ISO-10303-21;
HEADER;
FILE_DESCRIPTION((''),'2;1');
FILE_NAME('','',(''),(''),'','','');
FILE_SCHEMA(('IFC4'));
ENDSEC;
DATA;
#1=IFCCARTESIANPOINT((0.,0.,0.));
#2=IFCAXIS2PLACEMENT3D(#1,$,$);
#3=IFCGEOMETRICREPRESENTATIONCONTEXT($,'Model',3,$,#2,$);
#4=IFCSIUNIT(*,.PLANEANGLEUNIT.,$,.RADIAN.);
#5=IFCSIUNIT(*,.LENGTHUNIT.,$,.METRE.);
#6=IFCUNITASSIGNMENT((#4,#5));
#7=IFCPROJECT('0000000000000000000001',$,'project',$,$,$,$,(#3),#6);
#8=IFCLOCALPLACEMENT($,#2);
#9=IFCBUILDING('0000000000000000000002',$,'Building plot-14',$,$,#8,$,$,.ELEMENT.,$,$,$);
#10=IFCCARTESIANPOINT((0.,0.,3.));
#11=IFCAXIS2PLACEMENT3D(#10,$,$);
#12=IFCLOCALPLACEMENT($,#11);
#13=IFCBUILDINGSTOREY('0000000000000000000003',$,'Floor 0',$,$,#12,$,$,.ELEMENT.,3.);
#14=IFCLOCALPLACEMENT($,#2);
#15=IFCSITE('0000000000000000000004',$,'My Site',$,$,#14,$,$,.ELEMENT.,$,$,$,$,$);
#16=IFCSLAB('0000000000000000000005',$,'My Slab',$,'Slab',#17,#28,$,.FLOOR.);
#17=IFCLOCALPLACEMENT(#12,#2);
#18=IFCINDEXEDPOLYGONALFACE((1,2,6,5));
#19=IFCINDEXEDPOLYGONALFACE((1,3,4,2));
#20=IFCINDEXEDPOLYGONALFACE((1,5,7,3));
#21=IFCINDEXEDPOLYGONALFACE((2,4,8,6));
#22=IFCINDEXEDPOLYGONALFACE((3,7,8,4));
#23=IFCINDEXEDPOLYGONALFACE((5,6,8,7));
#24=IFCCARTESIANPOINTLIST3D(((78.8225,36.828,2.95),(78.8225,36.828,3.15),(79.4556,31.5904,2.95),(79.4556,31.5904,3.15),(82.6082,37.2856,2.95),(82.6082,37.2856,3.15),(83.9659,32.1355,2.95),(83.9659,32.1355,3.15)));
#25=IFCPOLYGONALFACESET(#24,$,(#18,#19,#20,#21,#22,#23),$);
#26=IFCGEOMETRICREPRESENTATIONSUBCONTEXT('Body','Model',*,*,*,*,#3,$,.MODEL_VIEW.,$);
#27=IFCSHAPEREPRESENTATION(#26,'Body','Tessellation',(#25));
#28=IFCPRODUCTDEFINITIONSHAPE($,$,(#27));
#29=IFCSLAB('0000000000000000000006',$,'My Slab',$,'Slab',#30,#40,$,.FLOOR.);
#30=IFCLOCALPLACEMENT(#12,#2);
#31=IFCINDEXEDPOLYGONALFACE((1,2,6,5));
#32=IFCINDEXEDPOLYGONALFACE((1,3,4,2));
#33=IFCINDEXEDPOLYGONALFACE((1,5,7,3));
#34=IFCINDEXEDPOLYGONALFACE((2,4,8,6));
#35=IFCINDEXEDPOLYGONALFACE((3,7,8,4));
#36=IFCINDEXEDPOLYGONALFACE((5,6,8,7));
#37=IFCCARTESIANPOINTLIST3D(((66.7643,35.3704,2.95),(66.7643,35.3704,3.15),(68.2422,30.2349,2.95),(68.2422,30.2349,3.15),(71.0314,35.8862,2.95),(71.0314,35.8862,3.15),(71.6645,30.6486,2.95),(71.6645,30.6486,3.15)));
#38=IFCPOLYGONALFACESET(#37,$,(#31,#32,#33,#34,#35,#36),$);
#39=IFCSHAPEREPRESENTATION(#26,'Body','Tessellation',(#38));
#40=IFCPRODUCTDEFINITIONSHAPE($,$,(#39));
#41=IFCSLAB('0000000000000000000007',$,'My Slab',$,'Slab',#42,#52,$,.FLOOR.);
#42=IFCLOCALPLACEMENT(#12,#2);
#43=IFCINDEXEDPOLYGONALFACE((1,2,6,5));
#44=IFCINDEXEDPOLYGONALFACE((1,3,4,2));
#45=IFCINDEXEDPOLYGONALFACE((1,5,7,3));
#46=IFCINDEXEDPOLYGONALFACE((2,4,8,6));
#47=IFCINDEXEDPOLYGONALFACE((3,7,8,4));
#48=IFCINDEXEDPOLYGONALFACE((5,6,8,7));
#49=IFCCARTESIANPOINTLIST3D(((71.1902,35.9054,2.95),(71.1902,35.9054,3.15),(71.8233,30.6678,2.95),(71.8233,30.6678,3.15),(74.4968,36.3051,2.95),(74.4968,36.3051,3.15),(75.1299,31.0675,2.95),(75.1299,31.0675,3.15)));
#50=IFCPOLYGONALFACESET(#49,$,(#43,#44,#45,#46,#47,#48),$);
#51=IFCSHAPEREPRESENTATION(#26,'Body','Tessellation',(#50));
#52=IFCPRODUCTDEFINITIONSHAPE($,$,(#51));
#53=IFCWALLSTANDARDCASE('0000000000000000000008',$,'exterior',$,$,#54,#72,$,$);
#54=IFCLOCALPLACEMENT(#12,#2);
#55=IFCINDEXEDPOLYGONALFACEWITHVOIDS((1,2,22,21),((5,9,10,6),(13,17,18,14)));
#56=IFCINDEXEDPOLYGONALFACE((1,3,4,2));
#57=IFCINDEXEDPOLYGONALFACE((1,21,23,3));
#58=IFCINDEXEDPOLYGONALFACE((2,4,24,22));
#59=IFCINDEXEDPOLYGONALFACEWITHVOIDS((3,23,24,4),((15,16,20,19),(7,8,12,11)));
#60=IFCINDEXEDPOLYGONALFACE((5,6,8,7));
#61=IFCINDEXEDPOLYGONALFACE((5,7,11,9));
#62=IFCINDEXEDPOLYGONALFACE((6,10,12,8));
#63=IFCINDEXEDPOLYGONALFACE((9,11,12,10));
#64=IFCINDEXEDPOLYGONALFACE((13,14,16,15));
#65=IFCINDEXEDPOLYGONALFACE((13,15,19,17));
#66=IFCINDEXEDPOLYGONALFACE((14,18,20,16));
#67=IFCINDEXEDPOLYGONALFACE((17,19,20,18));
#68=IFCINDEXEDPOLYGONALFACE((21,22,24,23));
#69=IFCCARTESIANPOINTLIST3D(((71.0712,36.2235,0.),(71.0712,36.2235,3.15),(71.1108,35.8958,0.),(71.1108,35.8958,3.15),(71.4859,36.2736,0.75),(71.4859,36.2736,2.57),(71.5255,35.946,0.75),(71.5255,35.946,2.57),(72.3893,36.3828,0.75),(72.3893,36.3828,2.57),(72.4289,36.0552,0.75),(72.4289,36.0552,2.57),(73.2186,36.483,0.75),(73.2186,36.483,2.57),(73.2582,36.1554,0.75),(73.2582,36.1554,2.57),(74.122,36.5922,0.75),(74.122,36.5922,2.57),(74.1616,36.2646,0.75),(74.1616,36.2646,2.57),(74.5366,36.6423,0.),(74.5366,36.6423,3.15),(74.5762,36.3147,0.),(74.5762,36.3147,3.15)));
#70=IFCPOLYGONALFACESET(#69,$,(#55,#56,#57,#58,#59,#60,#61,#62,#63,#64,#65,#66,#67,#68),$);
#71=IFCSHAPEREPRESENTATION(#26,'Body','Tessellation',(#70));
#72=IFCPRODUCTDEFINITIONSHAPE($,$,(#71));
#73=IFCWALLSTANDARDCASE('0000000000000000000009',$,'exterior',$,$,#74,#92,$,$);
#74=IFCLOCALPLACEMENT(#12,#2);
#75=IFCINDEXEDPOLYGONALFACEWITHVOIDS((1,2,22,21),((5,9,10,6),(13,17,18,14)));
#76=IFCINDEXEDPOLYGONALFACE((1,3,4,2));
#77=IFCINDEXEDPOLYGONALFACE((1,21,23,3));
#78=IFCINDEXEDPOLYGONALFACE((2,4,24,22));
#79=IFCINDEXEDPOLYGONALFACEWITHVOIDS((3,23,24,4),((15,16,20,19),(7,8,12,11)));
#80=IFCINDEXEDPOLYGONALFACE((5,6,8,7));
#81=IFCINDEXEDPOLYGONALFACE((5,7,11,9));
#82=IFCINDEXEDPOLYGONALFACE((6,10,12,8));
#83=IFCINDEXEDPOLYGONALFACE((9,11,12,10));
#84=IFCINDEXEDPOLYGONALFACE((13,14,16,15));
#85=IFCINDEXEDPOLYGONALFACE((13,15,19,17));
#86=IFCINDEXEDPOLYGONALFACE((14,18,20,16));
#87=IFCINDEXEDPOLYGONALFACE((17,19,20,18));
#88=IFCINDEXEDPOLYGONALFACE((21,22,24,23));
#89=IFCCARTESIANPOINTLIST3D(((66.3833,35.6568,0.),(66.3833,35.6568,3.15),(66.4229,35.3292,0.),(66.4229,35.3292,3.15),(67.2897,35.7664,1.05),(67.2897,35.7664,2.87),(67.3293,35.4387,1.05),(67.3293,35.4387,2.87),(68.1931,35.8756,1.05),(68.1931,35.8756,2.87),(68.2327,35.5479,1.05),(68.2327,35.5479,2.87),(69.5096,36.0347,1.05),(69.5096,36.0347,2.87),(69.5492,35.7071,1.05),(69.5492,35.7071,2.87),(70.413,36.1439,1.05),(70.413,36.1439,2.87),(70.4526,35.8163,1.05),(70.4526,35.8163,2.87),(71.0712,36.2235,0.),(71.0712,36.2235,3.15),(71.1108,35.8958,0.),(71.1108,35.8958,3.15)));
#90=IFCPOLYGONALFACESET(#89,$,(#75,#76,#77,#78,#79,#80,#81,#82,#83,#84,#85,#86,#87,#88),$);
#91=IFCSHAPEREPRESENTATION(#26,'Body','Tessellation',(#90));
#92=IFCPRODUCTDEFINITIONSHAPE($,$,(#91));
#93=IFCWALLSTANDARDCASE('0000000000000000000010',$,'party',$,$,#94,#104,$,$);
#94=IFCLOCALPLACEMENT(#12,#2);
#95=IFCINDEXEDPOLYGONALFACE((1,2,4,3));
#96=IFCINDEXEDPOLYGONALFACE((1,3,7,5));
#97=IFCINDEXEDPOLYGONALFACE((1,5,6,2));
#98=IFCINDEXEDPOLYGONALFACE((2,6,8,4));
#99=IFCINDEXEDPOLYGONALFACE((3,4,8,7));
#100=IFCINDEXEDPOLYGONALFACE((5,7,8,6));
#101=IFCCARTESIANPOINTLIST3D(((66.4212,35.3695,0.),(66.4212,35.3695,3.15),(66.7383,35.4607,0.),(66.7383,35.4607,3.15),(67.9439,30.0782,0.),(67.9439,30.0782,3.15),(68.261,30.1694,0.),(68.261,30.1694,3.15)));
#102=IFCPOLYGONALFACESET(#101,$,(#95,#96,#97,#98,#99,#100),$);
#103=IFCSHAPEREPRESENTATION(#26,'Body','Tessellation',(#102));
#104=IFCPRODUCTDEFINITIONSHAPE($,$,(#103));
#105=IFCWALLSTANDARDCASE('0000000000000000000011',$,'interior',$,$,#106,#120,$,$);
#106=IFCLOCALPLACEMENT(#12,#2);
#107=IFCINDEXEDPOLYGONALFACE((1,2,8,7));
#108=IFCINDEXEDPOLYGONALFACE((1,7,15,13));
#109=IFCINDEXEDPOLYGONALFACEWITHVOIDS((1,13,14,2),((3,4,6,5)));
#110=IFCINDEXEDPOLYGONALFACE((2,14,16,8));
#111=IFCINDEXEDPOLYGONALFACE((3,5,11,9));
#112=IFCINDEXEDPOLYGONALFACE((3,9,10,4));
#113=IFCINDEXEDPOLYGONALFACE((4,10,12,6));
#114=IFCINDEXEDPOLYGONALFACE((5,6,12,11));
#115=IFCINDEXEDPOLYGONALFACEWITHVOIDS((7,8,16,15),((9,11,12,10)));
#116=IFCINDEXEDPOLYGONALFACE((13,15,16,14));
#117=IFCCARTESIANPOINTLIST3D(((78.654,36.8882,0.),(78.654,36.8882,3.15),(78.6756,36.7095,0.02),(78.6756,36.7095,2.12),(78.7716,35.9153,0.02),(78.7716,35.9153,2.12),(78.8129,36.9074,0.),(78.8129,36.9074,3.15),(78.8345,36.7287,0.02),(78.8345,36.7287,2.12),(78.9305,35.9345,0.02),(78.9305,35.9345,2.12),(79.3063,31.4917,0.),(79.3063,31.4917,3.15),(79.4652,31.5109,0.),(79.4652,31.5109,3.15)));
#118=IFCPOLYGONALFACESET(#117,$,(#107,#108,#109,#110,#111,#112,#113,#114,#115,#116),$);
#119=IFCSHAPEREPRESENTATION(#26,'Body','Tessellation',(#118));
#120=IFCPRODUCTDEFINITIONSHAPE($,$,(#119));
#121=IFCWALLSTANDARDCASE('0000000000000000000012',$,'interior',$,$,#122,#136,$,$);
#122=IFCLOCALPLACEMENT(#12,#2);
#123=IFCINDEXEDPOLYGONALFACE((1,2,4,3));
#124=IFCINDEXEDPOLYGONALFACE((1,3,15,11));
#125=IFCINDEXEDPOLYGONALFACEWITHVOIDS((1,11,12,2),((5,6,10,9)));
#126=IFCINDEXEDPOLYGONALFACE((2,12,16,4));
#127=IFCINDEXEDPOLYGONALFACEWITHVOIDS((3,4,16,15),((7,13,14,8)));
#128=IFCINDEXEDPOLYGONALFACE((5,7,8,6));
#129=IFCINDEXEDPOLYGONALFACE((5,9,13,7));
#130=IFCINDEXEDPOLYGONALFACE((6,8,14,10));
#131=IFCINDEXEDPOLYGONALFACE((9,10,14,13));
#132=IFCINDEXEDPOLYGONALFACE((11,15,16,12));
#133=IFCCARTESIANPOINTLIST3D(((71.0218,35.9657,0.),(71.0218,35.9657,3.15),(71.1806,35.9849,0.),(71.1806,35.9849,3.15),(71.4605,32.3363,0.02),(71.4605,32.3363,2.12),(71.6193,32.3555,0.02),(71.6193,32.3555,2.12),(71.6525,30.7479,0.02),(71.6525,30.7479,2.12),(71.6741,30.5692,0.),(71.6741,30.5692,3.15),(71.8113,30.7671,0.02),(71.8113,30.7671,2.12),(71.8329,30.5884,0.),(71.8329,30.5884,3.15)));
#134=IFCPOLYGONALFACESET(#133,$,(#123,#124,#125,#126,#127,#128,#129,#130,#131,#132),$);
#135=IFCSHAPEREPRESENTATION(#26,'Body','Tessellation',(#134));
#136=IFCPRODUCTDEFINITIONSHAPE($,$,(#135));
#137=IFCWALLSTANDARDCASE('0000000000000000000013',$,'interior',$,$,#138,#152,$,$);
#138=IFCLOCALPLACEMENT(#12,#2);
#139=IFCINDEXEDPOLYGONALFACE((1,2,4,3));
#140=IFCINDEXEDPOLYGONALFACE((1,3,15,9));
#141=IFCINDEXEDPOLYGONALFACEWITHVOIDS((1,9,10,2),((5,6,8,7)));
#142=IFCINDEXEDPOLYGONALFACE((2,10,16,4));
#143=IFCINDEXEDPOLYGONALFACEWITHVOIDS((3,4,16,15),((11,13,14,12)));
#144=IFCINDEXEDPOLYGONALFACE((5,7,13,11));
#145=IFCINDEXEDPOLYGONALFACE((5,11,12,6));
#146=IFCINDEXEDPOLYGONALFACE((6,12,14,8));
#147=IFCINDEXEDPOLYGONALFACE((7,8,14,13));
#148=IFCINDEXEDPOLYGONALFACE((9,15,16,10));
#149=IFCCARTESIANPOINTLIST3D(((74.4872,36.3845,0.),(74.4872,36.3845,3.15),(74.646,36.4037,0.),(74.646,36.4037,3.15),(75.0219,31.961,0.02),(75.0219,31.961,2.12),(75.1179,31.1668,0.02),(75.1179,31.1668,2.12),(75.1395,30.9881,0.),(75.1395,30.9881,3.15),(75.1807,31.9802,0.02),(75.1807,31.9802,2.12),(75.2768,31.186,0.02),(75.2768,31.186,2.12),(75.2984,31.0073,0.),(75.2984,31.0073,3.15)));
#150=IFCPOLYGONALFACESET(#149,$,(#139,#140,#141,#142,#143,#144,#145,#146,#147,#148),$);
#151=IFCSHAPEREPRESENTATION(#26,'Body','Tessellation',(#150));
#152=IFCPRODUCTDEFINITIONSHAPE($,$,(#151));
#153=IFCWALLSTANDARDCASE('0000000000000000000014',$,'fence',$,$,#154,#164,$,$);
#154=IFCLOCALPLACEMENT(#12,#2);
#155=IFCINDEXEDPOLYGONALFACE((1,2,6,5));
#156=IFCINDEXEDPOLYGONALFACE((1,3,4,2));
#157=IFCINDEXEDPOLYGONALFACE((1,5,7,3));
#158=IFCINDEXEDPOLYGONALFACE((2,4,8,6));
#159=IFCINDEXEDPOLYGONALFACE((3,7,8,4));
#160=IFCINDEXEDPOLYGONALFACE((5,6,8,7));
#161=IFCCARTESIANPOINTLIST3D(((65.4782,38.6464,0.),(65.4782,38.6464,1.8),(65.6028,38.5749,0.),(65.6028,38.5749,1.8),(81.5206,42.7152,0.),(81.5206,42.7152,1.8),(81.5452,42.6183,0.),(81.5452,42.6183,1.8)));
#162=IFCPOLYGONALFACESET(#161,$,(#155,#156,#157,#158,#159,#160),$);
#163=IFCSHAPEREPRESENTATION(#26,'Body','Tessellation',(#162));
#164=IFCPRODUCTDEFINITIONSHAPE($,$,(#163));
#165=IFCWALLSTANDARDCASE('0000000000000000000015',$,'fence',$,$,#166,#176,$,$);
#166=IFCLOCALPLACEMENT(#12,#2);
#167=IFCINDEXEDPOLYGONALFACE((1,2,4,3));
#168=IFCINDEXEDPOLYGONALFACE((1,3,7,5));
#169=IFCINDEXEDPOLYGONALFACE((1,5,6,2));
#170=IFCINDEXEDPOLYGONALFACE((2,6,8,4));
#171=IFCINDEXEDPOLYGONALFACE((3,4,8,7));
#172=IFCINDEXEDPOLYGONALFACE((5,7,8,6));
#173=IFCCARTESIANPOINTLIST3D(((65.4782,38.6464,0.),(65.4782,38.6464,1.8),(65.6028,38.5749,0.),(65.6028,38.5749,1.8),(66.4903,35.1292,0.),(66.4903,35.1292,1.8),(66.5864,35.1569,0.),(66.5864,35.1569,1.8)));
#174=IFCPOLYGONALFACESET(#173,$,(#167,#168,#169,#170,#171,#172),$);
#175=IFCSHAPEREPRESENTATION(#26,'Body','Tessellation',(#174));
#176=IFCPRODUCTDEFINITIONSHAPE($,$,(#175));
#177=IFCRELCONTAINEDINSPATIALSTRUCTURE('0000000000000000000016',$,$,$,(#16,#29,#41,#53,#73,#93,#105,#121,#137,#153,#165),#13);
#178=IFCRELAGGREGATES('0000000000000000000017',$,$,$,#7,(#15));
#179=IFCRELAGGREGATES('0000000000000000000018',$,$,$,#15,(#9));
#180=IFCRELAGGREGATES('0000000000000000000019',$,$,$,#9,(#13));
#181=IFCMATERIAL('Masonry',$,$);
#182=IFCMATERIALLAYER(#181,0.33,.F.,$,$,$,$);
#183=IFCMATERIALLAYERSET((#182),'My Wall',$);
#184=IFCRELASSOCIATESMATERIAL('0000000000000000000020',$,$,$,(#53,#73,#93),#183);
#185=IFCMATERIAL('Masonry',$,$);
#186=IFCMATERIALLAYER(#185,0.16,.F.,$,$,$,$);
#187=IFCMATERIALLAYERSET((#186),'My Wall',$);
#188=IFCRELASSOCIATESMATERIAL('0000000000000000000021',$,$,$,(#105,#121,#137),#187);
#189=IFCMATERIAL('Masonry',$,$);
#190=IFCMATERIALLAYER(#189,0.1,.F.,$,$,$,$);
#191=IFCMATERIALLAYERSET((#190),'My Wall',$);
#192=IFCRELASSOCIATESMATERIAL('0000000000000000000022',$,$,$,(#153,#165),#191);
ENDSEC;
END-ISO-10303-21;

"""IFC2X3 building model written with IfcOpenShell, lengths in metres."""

from ifc_helpers import new_model, si_unit, frame, origin, place, context, subcontext, project, spatial, polyline, outline, extrude, material, layer, layer_set, layer_usage, element, save


model = new_model("IFC2X3")

# Units and contexts
model_context = context("Model", 3, world=origin())
body_context = subcontext(model_context, "Body", "Model", "MODEL_VIEW")
ifc_project = project(units=[si_unit("PLANEANGLEUNIT", "RADIAN"), si_unit("LENGTHUNIT", "METRE")], contexts=[model_context])

# Site, building, storey
site_placement = place(None, origin())
site = spatial("IfcSite", under=ifc_project, at=site_placement, Name="My Site", CompositionType="ELEMENT")
building_placement = place(None, origin())
building = spatial("IfcBuilding", under=site, at=building_placement, Name="Building plot-14", CompositionType="ELEMENT")
storey_placement = place(None, frame((0.0, 0.0, 3.0)))
storey = spatial("IfcBuildingStorey", under=building, at=storey_placement, Name="Floor 0", CompositionType="ELEMENT", Elevation=3.0)

# Slabs
slab_1_placement = place(storey_placement, frame((0.0, 0.0, 2.95)))
element("IfcSlab", 1, at=slab_1_placement, inside=storey, Name="My Slab", ObjectType="Slab", PredefinedType="FLOOR", context=body_context, shape_type="SweptSolid", body=[
    extrude(outline(polyline([(83.9659, 32.1355), (82.6082, 37.2856), (78.8225, 36.828), (79.4556, 31.5904), (83.9659, 32.1355)])), origin(), (0.0, 0.0, 1.0), 0.2),
])
slab_2_placement = place(storey_placement, frame((0.0, 0.0, 2.95)))
element("IfcSlab", 2, at=slab_2_placement, inside=storey, Name="My Slab", ObjectType="Slab", PredefinedType="FLOOR", context=body_context, shape_type="SweptSolid", body=[
    extrude(outline(polyline([(71.0314, 35.8862), (66.7643, 35.3704), (68.2422, 30.2349), (71.6645, 30.6486), (71.0314, 35.8862)])), origin(), (0.0, 0.0, 1.0), 0.2),
])
slab_3_placement = place(storey_placement, frame((0.0, 0.0, 2.95)))
element("IfcSlab", 3, at=slab_3_placement, inside=storey, Name="My Slab", ObjectType="Slab", PredefinedType="FLOOR", context=body_context, shape_type="SweptSolid", body=[
    extrude(outline(polyline([(75.1299, 31.0675), (74.4968, 36.3051), (71.1902, 35.9054), (71.8233, 30.6678), (75.1299, 31.0675)])), origin(), (0.0, 0.0, 1.0), 0.2),
])

# Walls, openings
ifc_material_1 = material(Name="Masonry")
ifc_layer_1 = layer(ifc_material_1, 0.33, ventilated=False)
ifc_layer_set_1 = layer_set([ifc_layer_1], Name="My Wall")
ifc_layer_usage_1 = layer_usage(ifc_layer_set_1, "AXIS2", "NEGATIVE", 0.08)
wall_1_placement = place(storey_placement, origin())
wall_1 = element("IfcWallStandardCase", 4, at=wall_1_placement, inside=storey, material=ifc_layer_usage_1, Name="exterior", context=body_context, shape_type="SweptSolid", body=[
    extrude(outline(polyline([(74.5762, 36.3147), (74.5366, 36.6423), (71.0712, 36.2235), (71.1108, 35.8958), (74.5762, 36.3147)])), origin(), (0.0, 0.0, 1.0), 3.15),
])
opening_1_placement = place(storey_placement, frame((0.0, 0.0, 0.75)))
element("IfcOpeningElement", 5, at=opening_1_placement, cuts=wall_1, ObjectType="Opening", context=body_context, shape_type="SweptSolid", body=[
    extrude(outline(polyline([(74.122, 36.5922), (73.2186, 36.483), (73.2582, 36.1554), (74.1616, 36.2646), (74.122, 36.5922)])), origin(), (0.0, 0.0, 1.0), 1.82),
])
opening_2_placement = place(storey_placement, frame((0.0, 0.0, 0.75)))
element("IfcOpeningElement", 6, at=opening_2_placement, cuts=wall_1, ObjectType="Opening", context=body_context, shape_type="SweptSolid", body=[
    extrude(outline(polyline([(72.3893, 36.3828), (71.4859, 36.2736), (71.5255, 35.946), (72.4289, 36.0552), (72.3893, 36.3828)])), origin(), (0.0, 0.0, 1.0), 1.82),
])
wall_2_placement = place(storey_placement, origin())
wall_2 = element("IfcWallStandardCase", 7, at=wall_2_placement, inside=storey, material=ifc_layer_usage_1, Name="exterior", context=body_context, shape_type="SweptSolid", body=[
    extrude(outline(polyline([(71.1108, 35.8958), (71.0712, 36.2235), (66.3833, 35.6568), (66.4229, 35.3292), (71.1108, 35.8958)])), origin(), (0.0, 0.0, 1.0), 3.15),
])
opening_3_placement = place(storey_placement, frame((0.0, 0.0, 1.05)))
element("IfcOpeningElement", 8, at=opening_3_placement, cuts=wall_2, ObjectType="Opening", context=body_context, shape_type="SweptSolid", body=[
    extrude(outline(polyline([(70.413, 36.1439), (69.5096, 36.0347), (69.5492, 35.7071), (70.4526, 35.8163), (70.413, 36.1439)])), origin(), (0.0, 0.0, 1.0), 1.82),
])
opening_4_placement = place(storey_placement, frame((0.0, 0.0, 1.05)))
element("IfcOpeningElement", 9, at=opening_4_placement, cuts=wall_2, ObjectType="Opening", context=body_context, shape_type="SweptSolid", body=[
    extrude(outline(polyline([(68.1931, 35.8756), (67.2897, 35.7664), (67.3293, 35.4387), (68.2327, 35.5479), (68.1931, 35.8756)])), origin(), (0.0, 0.0, 1.0), 1.82),
])

# Wall
wall_3_placement = place(storey_placement, origin())
element("IfcWallStandardCase", 10, at=wall_3_placement, inside=storey, material=ifc_layer_usage_1, Name="party", context=body_context, shape_type="SweptSolid", body=[
    extrude(outline(polyline([(66.7383, 35.4607), (66.4212, 35.3695), (67.9439, 30.0782), (68.261, 30.1694), (66.7383, 35.4607)])), origin(), (0.0, 0.0, 1.0), 3.15),
])

# Walls, openings
ifc_material_2 = material(Name="Masonry")
ifc_layer_2 = layer(ifc_material_2, 0.16, ventilated=False)
ifc_layer_set_2 = layer_set([ifc_layer_2], Name="My Wall")
ifc_layer_usage_2 = layer_usage(ifc_layer_set_2, "AXIS2", "NEGATIVE", 0.08)
wall_4_placement = place(storey_placement, origin())
wall_4 = element("IfcWallStandardCase", 11, at=wall_4_placement, inside=storey, material=ifc_layer_usage_2, Name="interior", context=body_context, shape_type="SweptSolid", body=[
    extrude(outline(polyline([(79.3063, 31.4917), (79.4652, 31.5109), (78.8129, 36.9074), (78.654, 36.8882), (79.3063, 31.4917)])), origin(), (0.0, 0.0, 1.0), 3.15),
])
opening_5_placement = place(storey_placement, frame((0.0, 0.0, 0.02)))
element("IfcOpeningElement", 12, at=opening_5_placement, cuts=wall_4, ObjectType="Opening", context=body_context, shape_type="SweptSolid", body=[
    extrude(outline(polyline([(78.9305, 35.9345), (78.8345, 36.7287), (78.6756, 36.7095), (78.7716, 35.9153), (78.9305, 35.9345)])), origin(), (0.0, 0.0, 1.0), 2.1),
])
wall_5_placement = place(storey_placement, origin())
wall_5 = element("IfcWallStandardCase", 13, at=wall_5_placement, inside=storey, material=ifc_layer_usage_2, Name="interior", context=body_context, shape_type="SweptSolid", body=[
    extrude(outline(polyline([(71.6741, 30.5692), (71.8329, 30.5884), (71.1806, 35.9849), (71.0218, 35.9657), (71.6741, 30.5692)])), origin(), (0.0, 0.0, 1.0), 3.15),
])
opening_6_placement = place(storey_placement, frame((0.0, 0.0, 0.02)))
element("IfcOpeningElement", 14, at=opening_6_placement, cuts=wall_5, ObjectType="Opening", context=body_context, shape_type="SweptSolid", body=[
    extrude(outline(polyline([(71.8113, 30.7671), (71.6193, 32.3555), (71.4605, 32.3363), (71.6525, 30.7479), (71.8113, 30.7671)])), origin(), (0.0, 0.0, 1.0), 2.1),
])
wall_6_placement = place(storey_placement, origin())
wall_6 = element("IfcWallStandardCase", 15, at=wall_6_placement, inside=storey, material=ifc_layer_usage_2, Name="interior", context=body_context, shape_type="SweptSolid", body=[
    extrude(outline(polyline([(74.646, 36.4037), (74.4872, 36.3845), (75.1395, 30.9881), (75.2984, 31.0073), (74.646, 36.4037)])), origin(), (0.0, 0.0, 1.0), 3.15),
])
opening_7_placement = place(storey_placement, frame((0.0, 0.0, 0.02)))
element("IfcOpeningElement", 16, at=opening_7_placement, cuts=wall_6, ObjectType="Opening", context=body_context, shape_type="SweptSolid", body=[
    extrude(outline(polyline([(75.0219, 31.961), (75.1179, 31.1668), (75.2768, 31.186), (75.1807, 31.9802), (75.0219, 31.961)])), origin(), (0.0, 0.0, 1.0), 2.1),
])

# Walls
ifc_material_3 = material(Name="Masonry")
ifc_layer_3 = layer(ifc_material_3, 0.1, ventilated=False)
ifc_layer_set_3 = layer_set([ifc_layer_3], Name="My Wall")
ifc_layer_usage_3 = layer_usage(ifc_layer_set_3, "AXIS2", "NEGATIVE", -0.15)
wall_7_placement = place(storey_placement, origin())
element("IfcWallStandardCase", 17, at=wall_7_placement, inside=storey, material=ifc_layer_usage_3, Name="fence", context=body_context, shape_type="SweptSolid", body=[
    extrude(outline(polyline([(81.5452, 42.6183), (81.5206, 42.7152), (65.4782, 38.6464), (65.6028, 38.5749), (81.5452, 42.6183)])), origin(), (0.0, 0.0, 1.0), 1.8),
])
wall_8_placement = place(storey_placement, origin())
element("IfcWallStandardCase", 18, at=wall_8_placement, inside=storey, material=ifc_layer_usage_3, Name="fence", context=body_context, shape_type="SweptSolid", body=[
    extrude(outline(polyline([(65.6028, 38.5749), (65.4782, 38.6464), (66.4903, 35.1292), (66.5864, 35.1569), (65.6028, 38.5749)])), origin(), (0.0, 0.0, 1.0), 1.8),
])

save(model, "model.ifc")
